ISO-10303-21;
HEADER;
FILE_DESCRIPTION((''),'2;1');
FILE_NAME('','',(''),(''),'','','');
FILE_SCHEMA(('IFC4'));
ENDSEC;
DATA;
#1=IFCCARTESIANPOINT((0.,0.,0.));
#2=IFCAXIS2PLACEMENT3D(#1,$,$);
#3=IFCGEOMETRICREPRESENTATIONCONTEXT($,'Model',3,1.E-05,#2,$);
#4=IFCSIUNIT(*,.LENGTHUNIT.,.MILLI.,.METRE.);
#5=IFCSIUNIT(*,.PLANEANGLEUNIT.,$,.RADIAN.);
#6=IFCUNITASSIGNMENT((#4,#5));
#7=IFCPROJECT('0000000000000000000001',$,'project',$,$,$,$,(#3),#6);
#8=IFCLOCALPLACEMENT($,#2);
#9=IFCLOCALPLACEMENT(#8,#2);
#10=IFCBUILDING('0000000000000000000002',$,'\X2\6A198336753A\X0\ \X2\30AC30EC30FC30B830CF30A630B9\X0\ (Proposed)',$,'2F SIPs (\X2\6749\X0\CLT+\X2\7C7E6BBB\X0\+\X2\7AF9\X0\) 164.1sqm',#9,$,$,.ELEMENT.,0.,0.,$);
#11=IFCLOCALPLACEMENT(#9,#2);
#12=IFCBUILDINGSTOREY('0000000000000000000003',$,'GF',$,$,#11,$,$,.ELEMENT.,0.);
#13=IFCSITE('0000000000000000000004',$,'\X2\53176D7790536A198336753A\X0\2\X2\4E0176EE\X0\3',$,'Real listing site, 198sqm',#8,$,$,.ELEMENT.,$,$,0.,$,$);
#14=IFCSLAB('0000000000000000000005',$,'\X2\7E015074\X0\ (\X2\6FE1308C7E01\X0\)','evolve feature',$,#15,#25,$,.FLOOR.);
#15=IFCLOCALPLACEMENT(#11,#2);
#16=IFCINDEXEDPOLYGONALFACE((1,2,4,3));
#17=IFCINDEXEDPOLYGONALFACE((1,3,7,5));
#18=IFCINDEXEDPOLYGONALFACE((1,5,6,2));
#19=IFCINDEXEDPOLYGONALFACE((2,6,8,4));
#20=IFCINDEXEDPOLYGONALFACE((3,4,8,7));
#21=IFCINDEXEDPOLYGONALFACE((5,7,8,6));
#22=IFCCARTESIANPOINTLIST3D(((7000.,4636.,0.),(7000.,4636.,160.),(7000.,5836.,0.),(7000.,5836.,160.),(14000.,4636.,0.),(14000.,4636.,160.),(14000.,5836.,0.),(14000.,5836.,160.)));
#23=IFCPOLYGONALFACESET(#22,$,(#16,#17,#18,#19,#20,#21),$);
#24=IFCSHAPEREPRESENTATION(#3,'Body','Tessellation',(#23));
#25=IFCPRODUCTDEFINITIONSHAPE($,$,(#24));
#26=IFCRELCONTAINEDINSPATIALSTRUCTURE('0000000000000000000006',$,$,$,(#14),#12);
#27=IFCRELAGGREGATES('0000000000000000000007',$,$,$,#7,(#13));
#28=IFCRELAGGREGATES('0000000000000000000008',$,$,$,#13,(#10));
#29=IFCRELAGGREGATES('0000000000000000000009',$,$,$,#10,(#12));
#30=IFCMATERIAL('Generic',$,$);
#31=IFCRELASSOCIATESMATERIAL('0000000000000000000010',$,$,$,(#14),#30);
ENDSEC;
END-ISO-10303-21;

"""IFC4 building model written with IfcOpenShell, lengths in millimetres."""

from ifc_helpers import new_model, si_unit, frame, frame_2d, origin, place, context, project, spatial, rectangle, extrude, material, element, save


model = new_model("IFC4")

# Units and contexts
model_context = context("Model", 3, precision=1e-05, world=origin())
ifc_project = project(units=[si_unit("LENGTHUNIT", "METRE", prefix="MILLI"), si_unit("PLANEANGLEUNIT", "RADIAN")], contexts=[model_context])

# Site, building, storey
site_placement = place(None, origin())
site = spatial("IfcSite", under=ifc_project, at=site_placement, Name="北海道標茶町2丁目3", ObjectType="Real listing site, 198sqm", CompositionType="ELEMENT", RefElevation=0.0)
building_placement = place(site_placement, origin())
building = spatial("IfcBuilding", under=site, at=building_placement, Name="標茶町 ガレージハウス (Proposed)", ObjectType="2F SIPs (杉CLT+籾殻+竹) 164.1sqm", CompositionType="ELEMENT", ElevationOfRefHeight=0.0, ElevationOfTerrain=0.0)
storey_placement = place(building_placement, origin())
storey = spatial("IfcBuildingStorey", under=building, at=storey_placement, Name="GF", CompositionType="ELEMENT", Elevation=0.0)

# Slab
ifc_material_1 = material(Name="Generic")
slab_1_placement = place(storey_placement, frame((3500.0, 2318.0, 0.0)))
element("IfcSlab", 1, at=slab_1_placement, inside=storey, material=ifc_material_1, Name="縁側 (濡れ縁)", Description="evolve feature", PredefinedType="FLOOR", context=model_context, shape_type="SweptSolid", body=[
    extrude(rectangle(XDim=7000.0, YDim=1200.0, at=frame_2d((3500.0, 600.0))), frame((3500.0, 2318.0, 0.0)), (0.0, 0.0, 1.0), 160.0),
])

save(model, "model.ifc")
